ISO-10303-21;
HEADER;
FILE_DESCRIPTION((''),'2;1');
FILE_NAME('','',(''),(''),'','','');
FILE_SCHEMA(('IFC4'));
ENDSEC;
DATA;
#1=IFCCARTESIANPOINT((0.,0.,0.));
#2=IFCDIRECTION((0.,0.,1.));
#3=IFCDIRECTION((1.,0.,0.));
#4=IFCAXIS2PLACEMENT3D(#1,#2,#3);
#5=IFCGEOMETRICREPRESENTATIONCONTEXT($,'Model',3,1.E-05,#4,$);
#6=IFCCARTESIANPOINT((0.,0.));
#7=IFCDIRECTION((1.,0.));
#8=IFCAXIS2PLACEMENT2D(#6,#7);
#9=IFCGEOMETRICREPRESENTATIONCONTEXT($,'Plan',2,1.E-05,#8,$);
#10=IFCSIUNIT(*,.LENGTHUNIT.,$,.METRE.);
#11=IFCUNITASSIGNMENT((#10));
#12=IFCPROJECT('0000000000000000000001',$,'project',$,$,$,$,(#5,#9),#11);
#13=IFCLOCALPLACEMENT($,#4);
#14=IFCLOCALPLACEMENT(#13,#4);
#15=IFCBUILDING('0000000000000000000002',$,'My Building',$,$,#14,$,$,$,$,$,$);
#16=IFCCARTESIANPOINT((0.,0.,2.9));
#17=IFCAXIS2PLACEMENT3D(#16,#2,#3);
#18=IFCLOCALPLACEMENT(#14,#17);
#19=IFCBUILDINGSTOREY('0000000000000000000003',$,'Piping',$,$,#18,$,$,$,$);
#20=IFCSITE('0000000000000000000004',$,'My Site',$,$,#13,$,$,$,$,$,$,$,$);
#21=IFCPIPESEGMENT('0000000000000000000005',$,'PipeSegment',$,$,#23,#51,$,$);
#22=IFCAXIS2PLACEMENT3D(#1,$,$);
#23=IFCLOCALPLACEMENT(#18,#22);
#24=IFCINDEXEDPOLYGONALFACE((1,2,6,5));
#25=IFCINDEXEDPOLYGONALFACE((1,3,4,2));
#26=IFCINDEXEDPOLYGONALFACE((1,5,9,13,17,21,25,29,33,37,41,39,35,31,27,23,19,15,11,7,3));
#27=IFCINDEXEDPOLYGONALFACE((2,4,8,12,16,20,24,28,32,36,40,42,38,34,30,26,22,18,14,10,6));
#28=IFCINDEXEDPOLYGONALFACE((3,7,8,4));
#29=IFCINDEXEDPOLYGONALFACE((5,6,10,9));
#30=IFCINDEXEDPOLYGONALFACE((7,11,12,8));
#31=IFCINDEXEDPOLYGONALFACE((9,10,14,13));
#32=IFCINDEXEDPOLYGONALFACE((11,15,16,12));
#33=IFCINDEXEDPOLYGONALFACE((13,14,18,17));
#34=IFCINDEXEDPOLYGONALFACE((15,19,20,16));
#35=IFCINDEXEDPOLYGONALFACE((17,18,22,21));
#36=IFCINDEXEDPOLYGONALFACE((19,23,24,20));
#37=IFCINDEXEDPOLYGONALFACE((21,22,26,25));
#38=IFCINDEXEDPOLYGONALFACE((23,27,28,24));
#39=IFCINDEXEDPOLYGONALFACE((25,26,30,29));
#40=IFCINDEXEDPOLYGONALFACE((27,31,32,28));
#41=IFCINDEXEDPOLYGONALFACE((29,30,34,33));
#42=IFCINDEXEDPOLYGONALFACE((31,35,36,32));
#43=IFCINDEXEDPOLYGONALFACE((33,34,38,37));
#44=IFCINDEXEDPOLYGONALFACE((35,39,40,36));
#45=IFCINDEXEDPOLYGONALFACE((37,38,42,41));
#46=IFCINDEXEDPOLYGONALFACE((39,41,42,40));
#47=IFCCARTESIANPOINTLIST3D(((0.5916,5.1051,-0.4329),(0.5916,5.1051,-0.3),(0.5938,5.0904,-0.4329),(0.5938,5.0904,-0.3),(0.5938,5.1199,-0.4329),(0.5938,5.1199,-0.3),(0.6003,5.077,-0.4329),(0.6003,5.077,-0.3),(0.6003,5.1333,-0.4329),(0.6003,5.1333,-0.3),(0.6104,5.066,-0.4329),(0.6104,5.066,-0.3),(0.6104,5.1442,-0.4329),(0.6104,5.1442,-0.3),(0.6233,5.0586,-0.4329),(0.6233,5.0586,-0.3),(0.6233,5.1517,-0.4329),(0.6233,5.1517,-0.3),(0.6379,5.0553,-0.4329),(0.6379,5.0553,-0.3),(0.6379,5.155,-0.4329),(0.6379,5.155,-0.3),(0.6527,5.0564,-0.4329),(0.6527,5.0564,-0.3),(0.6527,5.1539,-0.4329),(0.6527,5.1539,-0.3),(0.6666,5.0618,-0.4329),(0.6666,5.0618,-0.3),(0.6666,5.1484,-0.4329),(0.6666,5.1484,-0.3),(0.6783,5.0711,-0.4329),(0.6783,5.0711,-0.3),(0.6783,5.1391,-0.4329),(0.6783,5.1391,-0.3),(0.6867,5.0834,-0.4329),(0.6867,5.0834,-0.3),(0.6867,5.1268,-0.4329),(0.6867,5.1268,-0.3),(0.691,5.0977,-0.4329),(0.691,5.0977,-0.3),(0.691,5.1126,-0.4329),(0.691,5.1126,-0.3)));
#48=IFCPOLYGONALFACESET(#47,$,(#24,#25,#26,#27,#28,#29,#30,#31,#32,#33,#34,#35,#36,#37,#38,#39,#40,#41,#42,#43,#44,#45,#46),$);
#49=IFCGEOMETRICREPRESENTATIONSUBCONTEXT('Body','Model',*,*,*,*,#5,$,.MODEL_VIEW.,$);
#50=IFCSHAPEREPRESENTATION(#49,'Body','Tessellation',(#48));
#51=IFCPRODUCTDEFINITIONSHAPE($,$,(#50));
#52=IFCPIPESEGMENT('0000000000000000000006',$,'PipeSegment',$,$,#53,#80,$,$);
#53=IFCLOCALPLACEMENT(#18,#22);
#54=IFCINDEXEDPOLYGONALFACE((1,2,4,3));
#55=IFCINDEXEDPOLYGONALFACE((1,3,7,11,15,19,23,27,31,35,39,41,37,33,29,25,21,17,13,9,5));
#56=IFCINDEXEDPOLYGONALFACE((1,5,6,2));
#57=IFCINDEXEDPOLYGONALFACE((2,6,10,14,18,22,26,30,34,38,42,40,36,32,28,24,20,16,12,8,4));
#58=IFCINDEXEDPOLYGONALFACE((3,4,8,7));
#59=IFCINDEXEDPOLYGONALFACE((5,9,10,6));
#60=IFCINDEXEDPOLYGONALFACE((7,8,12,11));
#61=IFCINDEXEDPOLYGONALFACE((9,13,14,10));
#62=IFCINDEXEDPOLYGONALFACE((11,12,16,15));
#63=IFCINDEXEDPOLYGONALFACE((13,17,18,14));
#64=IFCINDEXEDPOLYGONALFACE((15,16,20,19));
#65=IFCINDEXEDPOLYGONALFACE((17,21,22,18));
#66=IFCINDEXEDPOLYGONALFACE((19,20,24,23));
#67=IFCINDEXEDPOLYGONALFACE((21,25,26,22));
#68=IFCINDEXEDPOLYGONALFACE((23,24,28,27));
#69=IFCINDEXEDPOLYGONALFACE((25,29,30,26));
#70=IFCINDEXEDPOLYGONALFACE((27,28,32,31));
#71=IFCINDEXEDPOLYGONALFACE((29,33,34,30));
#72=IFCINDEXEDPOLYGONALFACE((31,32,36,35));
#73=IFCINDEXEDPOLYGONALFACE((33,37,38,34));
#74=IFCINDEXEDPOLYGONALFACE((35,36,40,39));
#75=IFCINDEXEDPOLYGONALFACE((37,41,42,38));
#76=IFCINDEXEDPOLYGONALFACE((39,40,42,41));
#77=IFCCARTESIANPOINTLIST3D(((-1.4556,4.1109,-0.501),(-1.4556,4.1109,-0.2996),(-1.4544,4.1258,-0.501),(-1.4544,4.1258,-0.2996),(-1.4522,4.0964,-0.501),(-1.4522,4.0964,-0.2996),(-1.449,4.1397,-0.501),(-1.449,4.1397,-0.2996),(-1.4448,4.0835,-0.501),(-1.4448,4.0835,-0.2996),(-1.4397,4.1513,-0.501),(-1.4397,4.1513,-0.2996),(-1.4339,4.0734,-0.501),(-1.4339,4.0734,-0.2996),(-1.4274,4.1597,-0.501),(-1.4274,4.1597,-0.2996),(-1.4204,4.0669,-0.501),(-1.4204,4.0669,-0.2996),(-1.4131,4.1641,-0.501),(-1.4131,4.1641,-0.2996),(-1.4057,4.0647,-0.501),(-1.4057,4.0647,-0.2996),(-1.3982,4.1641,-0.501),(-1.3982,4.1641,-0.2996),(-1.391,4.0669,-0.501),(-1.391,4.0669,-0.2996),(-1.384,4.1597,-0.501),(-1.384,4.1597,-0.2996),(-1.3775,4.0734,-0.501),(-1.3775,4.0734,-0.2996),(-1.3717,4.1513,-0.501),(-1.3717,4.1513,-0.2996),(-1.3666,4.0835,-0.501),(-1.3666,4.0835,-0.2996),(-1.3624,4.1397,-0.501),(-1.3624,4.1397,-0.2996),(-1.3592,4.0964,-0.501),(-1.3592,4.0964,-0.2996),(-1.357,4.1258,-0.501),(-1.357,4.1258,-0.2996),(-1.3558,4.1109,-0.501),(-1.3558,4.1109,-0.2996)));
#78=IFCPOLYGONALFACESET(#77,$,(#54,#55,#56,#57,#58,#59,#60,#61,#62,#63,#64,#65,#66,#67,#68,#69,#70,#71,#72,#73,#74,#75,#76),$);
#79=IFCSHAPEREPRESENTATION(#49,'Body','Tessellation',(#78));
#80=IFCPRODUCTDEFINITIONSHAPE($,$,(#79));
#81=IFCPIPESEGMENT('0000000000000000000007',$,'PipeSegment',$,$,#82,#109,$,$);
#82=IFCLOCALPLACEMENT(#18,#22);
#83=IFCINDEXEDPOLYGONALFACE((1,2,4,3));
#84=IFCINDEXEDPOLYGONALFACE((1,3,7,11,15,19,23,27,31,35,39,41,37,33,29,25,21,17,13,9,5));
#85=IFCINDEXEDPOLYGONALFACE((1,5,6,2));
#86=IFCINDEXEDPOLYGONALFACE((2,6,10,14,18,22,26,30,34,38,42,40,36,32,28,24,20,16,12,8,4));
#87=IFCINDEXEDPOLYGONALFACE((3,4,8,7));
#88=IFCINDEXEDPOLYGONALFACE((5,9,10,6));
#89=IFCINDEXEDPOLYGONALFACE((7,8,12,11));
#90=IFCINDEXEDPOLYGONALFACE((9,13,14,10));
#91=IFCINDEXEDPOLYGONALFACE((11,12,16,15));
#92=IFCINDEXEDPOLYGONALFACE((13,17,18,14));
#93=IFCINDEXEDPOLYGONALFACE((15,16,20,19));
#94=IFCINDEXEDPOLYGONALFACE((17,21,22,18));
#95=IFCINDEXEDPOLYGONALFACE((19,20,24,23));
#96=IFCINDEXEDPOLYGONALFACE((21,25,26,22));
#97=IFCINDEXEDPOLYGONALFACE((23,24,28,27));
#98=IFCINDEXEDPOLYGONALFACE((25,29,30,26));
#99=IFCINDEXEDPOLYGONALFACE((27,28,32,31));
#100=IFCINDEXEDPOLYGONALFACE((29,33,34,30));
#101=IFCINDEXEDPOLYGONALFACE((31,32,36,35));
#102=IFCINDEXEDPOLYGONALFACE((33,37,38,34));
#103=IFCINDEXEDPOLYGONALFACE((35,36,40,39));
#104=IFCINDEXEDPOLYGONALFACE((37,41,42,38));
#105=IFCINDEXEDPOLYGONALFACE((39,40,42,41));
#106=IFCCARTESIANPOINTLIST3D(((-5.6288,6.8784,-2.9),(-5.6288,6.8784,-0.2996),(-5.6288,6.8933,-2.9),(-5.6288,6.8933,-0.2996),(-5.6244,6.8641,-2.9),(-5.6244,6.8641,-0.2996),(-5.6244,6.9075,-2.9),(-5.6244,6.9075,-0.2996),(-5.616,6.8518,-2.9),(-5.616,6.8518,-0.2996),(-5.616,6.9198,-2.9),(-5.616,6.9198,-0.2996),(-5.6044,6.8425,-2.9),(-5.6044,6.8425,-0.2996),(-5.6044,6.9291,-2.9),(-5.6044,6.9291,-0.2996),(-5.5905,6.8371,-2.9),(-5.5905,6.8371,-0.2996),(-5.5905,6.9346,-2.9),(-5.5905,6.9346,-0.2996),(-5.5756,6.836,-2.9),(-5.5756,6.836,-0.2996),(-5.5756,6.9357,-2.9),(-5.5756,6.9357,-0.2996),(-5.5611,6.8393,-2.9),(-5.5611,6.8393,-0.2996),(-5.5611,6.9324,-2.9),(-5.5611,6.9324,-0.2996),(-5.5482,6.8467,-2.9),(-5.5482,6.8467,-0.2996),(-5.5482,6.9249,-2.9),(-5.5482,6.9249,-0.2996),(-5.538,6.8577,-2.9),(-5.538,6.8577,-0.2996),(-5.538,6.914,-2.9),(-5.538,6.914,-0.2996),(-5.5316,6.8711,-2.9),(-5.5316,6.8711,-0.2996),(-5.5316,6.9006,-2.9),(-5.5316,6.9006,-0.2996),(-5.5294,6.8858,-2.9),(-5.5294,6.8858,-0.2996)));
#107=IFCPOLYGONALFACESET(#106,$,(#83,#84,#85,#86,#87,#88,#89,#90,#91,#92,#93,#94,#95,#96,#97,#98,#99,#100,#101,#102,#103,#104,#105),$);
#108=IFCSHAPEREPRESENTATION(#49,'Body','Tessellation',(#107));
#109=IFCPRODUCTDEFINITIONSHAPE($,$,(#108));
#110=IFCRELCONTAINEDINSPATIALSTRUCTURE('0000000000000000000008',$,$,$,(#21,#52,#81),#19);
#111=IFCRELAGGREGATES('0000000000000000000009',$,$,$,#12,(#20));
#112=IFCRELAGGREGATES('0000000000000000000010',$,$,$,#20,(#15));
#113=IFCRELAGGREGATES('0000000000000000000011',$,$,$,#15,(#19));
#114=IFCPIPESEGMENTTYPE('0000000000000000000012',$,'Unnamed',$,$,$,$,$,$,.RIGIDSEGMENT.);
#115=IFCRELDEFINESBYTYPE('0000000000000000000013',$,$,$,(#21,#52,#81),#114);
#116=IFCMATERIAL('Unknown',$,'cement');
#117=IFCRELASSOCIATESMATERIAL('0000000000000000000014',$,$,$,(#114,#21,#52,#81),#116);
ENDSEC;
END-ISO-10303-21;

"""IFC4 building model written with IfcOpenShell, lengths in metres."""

from ifc_helpers import new_model, si_unit, frame, origin_with_axes, origin_2d_with_axis, place, context, subcontext, project, spatial, circle, extrude, material, material_profile, profile_set, profile_usage, type_object, element, save


model = new_model("IFC4")

# Units and contexts
model_context = context("Model", 3, precision=1e-05, world=origin_with_axes())
plan_context = context("Plan", 2, precision=1e-05, world=origin_2d_with_axis())
body_context = subcontext(model_context, "Body", "Model", "MODEL_VIEW")
ifc_project = project(units=[si_unit("LENGTHUNIT", "METRE")], contexts=[model_context, plan_context])

# Site, building, storey
site_placement = place(None, origin_with_axes())
site = spatial("IfcSite", under=ifc_project, at=site_placement, Name="My Site")
building_placement = place(site_placement, origin_with_axes())
building = spatial("IfcBuilding", under=site, at=building_placement, Name="My Building")
storey_placement = place(building_placement, frame((0.0, 0.0, 2.9), z_axis=(0.0, 0.0, 1.0), x_axis=(1.0, 0.0, 0.0)))
storey = spatial("IfcBuildingStorey", under=building, at=storey_placement, Name="Piping")

# Pipe segments
ifc_material = material(Name="Unknown", Category="cement")
ifc_material_profile_1 = material_profile(ifc_material, circle(Radius=0.05))
ifc_profile_set_1 = profile_set([ifc_material_profile_1])
pipe_segment_type = type_object("IfcPipeSegmentType", Name="Unnamed", PredefinedType="RIGIDSEGMENT", material=ifc_profile_set_1)
ifc_profile_usage_1 = profile_usage(ifc_profile_set_1, cardinal=5)
pipe_segment_1_placement = place(storey_placement, frame((0.6416, 5.1051, -0.4329), z_axis=(0.0, 0.0, 1.0), x_axis=(-1.0, 0.0, 0.0)))
element("IfcPipeSegment", 1, at=pipe_segment_1_placement, inside=storey, type_object=pipe_segment_type, material=ifc_profile_usage_1, Name="PipeSegment", context=body_context, shape_type="SweptSolid", body=[
    extrude(circle(Radius=0.05), origin_with_axes(), (0.0, 0.0, 1.0), 0.1329),
])
ifc_profile_usage_2 = profile_usage(ifc_profile_set_1, cardinal=5)
pipe_segment_2_placement = place(storey_placement, frame((-1.4057, 4.1147, -0.501), z_axis=(0.0, 0.0, 1.0), x_axis=(0.0, -1.0, 0.0)))
element("IfcPipeSegment", 2, at=pipe_segment_2_placement, inside=storey, type_object=pipe_segment_type, material=ifc_profile_usage_2, Name="PipeSegment", context=body_context, shape_type="SweptSolid", body=[
    extrude(circle(Radius=0.05), origin_with_axes(), (0.0, 0.0, 1.0), 0.2013),
])
ifc_profile_usage_3 = profile_usage(ifc_profile_set_1, cardinal=5)
pipe_segment_3_placement = place(storey_placement, frame((-5.5794, 6.8858, -0.2996), z_axis=(0.0, 0.0, -1.0), x_axis=(1.0, 0.0, 0.0)))
element("IfcPipeSegment", 3, at=pipe_segment_3_placement, inside=storey, type_object=pipe_segment_type, material=ifc_profile_usage_3, Name="PipeSegment", context=body_context, shape_type="SweptSolid", body=[
    extrude(circle(Radius=0.05), origin_with_axes(), (0.0, 0.0, 1.0), 2.6004),
])

save(model, "model.ifc")
